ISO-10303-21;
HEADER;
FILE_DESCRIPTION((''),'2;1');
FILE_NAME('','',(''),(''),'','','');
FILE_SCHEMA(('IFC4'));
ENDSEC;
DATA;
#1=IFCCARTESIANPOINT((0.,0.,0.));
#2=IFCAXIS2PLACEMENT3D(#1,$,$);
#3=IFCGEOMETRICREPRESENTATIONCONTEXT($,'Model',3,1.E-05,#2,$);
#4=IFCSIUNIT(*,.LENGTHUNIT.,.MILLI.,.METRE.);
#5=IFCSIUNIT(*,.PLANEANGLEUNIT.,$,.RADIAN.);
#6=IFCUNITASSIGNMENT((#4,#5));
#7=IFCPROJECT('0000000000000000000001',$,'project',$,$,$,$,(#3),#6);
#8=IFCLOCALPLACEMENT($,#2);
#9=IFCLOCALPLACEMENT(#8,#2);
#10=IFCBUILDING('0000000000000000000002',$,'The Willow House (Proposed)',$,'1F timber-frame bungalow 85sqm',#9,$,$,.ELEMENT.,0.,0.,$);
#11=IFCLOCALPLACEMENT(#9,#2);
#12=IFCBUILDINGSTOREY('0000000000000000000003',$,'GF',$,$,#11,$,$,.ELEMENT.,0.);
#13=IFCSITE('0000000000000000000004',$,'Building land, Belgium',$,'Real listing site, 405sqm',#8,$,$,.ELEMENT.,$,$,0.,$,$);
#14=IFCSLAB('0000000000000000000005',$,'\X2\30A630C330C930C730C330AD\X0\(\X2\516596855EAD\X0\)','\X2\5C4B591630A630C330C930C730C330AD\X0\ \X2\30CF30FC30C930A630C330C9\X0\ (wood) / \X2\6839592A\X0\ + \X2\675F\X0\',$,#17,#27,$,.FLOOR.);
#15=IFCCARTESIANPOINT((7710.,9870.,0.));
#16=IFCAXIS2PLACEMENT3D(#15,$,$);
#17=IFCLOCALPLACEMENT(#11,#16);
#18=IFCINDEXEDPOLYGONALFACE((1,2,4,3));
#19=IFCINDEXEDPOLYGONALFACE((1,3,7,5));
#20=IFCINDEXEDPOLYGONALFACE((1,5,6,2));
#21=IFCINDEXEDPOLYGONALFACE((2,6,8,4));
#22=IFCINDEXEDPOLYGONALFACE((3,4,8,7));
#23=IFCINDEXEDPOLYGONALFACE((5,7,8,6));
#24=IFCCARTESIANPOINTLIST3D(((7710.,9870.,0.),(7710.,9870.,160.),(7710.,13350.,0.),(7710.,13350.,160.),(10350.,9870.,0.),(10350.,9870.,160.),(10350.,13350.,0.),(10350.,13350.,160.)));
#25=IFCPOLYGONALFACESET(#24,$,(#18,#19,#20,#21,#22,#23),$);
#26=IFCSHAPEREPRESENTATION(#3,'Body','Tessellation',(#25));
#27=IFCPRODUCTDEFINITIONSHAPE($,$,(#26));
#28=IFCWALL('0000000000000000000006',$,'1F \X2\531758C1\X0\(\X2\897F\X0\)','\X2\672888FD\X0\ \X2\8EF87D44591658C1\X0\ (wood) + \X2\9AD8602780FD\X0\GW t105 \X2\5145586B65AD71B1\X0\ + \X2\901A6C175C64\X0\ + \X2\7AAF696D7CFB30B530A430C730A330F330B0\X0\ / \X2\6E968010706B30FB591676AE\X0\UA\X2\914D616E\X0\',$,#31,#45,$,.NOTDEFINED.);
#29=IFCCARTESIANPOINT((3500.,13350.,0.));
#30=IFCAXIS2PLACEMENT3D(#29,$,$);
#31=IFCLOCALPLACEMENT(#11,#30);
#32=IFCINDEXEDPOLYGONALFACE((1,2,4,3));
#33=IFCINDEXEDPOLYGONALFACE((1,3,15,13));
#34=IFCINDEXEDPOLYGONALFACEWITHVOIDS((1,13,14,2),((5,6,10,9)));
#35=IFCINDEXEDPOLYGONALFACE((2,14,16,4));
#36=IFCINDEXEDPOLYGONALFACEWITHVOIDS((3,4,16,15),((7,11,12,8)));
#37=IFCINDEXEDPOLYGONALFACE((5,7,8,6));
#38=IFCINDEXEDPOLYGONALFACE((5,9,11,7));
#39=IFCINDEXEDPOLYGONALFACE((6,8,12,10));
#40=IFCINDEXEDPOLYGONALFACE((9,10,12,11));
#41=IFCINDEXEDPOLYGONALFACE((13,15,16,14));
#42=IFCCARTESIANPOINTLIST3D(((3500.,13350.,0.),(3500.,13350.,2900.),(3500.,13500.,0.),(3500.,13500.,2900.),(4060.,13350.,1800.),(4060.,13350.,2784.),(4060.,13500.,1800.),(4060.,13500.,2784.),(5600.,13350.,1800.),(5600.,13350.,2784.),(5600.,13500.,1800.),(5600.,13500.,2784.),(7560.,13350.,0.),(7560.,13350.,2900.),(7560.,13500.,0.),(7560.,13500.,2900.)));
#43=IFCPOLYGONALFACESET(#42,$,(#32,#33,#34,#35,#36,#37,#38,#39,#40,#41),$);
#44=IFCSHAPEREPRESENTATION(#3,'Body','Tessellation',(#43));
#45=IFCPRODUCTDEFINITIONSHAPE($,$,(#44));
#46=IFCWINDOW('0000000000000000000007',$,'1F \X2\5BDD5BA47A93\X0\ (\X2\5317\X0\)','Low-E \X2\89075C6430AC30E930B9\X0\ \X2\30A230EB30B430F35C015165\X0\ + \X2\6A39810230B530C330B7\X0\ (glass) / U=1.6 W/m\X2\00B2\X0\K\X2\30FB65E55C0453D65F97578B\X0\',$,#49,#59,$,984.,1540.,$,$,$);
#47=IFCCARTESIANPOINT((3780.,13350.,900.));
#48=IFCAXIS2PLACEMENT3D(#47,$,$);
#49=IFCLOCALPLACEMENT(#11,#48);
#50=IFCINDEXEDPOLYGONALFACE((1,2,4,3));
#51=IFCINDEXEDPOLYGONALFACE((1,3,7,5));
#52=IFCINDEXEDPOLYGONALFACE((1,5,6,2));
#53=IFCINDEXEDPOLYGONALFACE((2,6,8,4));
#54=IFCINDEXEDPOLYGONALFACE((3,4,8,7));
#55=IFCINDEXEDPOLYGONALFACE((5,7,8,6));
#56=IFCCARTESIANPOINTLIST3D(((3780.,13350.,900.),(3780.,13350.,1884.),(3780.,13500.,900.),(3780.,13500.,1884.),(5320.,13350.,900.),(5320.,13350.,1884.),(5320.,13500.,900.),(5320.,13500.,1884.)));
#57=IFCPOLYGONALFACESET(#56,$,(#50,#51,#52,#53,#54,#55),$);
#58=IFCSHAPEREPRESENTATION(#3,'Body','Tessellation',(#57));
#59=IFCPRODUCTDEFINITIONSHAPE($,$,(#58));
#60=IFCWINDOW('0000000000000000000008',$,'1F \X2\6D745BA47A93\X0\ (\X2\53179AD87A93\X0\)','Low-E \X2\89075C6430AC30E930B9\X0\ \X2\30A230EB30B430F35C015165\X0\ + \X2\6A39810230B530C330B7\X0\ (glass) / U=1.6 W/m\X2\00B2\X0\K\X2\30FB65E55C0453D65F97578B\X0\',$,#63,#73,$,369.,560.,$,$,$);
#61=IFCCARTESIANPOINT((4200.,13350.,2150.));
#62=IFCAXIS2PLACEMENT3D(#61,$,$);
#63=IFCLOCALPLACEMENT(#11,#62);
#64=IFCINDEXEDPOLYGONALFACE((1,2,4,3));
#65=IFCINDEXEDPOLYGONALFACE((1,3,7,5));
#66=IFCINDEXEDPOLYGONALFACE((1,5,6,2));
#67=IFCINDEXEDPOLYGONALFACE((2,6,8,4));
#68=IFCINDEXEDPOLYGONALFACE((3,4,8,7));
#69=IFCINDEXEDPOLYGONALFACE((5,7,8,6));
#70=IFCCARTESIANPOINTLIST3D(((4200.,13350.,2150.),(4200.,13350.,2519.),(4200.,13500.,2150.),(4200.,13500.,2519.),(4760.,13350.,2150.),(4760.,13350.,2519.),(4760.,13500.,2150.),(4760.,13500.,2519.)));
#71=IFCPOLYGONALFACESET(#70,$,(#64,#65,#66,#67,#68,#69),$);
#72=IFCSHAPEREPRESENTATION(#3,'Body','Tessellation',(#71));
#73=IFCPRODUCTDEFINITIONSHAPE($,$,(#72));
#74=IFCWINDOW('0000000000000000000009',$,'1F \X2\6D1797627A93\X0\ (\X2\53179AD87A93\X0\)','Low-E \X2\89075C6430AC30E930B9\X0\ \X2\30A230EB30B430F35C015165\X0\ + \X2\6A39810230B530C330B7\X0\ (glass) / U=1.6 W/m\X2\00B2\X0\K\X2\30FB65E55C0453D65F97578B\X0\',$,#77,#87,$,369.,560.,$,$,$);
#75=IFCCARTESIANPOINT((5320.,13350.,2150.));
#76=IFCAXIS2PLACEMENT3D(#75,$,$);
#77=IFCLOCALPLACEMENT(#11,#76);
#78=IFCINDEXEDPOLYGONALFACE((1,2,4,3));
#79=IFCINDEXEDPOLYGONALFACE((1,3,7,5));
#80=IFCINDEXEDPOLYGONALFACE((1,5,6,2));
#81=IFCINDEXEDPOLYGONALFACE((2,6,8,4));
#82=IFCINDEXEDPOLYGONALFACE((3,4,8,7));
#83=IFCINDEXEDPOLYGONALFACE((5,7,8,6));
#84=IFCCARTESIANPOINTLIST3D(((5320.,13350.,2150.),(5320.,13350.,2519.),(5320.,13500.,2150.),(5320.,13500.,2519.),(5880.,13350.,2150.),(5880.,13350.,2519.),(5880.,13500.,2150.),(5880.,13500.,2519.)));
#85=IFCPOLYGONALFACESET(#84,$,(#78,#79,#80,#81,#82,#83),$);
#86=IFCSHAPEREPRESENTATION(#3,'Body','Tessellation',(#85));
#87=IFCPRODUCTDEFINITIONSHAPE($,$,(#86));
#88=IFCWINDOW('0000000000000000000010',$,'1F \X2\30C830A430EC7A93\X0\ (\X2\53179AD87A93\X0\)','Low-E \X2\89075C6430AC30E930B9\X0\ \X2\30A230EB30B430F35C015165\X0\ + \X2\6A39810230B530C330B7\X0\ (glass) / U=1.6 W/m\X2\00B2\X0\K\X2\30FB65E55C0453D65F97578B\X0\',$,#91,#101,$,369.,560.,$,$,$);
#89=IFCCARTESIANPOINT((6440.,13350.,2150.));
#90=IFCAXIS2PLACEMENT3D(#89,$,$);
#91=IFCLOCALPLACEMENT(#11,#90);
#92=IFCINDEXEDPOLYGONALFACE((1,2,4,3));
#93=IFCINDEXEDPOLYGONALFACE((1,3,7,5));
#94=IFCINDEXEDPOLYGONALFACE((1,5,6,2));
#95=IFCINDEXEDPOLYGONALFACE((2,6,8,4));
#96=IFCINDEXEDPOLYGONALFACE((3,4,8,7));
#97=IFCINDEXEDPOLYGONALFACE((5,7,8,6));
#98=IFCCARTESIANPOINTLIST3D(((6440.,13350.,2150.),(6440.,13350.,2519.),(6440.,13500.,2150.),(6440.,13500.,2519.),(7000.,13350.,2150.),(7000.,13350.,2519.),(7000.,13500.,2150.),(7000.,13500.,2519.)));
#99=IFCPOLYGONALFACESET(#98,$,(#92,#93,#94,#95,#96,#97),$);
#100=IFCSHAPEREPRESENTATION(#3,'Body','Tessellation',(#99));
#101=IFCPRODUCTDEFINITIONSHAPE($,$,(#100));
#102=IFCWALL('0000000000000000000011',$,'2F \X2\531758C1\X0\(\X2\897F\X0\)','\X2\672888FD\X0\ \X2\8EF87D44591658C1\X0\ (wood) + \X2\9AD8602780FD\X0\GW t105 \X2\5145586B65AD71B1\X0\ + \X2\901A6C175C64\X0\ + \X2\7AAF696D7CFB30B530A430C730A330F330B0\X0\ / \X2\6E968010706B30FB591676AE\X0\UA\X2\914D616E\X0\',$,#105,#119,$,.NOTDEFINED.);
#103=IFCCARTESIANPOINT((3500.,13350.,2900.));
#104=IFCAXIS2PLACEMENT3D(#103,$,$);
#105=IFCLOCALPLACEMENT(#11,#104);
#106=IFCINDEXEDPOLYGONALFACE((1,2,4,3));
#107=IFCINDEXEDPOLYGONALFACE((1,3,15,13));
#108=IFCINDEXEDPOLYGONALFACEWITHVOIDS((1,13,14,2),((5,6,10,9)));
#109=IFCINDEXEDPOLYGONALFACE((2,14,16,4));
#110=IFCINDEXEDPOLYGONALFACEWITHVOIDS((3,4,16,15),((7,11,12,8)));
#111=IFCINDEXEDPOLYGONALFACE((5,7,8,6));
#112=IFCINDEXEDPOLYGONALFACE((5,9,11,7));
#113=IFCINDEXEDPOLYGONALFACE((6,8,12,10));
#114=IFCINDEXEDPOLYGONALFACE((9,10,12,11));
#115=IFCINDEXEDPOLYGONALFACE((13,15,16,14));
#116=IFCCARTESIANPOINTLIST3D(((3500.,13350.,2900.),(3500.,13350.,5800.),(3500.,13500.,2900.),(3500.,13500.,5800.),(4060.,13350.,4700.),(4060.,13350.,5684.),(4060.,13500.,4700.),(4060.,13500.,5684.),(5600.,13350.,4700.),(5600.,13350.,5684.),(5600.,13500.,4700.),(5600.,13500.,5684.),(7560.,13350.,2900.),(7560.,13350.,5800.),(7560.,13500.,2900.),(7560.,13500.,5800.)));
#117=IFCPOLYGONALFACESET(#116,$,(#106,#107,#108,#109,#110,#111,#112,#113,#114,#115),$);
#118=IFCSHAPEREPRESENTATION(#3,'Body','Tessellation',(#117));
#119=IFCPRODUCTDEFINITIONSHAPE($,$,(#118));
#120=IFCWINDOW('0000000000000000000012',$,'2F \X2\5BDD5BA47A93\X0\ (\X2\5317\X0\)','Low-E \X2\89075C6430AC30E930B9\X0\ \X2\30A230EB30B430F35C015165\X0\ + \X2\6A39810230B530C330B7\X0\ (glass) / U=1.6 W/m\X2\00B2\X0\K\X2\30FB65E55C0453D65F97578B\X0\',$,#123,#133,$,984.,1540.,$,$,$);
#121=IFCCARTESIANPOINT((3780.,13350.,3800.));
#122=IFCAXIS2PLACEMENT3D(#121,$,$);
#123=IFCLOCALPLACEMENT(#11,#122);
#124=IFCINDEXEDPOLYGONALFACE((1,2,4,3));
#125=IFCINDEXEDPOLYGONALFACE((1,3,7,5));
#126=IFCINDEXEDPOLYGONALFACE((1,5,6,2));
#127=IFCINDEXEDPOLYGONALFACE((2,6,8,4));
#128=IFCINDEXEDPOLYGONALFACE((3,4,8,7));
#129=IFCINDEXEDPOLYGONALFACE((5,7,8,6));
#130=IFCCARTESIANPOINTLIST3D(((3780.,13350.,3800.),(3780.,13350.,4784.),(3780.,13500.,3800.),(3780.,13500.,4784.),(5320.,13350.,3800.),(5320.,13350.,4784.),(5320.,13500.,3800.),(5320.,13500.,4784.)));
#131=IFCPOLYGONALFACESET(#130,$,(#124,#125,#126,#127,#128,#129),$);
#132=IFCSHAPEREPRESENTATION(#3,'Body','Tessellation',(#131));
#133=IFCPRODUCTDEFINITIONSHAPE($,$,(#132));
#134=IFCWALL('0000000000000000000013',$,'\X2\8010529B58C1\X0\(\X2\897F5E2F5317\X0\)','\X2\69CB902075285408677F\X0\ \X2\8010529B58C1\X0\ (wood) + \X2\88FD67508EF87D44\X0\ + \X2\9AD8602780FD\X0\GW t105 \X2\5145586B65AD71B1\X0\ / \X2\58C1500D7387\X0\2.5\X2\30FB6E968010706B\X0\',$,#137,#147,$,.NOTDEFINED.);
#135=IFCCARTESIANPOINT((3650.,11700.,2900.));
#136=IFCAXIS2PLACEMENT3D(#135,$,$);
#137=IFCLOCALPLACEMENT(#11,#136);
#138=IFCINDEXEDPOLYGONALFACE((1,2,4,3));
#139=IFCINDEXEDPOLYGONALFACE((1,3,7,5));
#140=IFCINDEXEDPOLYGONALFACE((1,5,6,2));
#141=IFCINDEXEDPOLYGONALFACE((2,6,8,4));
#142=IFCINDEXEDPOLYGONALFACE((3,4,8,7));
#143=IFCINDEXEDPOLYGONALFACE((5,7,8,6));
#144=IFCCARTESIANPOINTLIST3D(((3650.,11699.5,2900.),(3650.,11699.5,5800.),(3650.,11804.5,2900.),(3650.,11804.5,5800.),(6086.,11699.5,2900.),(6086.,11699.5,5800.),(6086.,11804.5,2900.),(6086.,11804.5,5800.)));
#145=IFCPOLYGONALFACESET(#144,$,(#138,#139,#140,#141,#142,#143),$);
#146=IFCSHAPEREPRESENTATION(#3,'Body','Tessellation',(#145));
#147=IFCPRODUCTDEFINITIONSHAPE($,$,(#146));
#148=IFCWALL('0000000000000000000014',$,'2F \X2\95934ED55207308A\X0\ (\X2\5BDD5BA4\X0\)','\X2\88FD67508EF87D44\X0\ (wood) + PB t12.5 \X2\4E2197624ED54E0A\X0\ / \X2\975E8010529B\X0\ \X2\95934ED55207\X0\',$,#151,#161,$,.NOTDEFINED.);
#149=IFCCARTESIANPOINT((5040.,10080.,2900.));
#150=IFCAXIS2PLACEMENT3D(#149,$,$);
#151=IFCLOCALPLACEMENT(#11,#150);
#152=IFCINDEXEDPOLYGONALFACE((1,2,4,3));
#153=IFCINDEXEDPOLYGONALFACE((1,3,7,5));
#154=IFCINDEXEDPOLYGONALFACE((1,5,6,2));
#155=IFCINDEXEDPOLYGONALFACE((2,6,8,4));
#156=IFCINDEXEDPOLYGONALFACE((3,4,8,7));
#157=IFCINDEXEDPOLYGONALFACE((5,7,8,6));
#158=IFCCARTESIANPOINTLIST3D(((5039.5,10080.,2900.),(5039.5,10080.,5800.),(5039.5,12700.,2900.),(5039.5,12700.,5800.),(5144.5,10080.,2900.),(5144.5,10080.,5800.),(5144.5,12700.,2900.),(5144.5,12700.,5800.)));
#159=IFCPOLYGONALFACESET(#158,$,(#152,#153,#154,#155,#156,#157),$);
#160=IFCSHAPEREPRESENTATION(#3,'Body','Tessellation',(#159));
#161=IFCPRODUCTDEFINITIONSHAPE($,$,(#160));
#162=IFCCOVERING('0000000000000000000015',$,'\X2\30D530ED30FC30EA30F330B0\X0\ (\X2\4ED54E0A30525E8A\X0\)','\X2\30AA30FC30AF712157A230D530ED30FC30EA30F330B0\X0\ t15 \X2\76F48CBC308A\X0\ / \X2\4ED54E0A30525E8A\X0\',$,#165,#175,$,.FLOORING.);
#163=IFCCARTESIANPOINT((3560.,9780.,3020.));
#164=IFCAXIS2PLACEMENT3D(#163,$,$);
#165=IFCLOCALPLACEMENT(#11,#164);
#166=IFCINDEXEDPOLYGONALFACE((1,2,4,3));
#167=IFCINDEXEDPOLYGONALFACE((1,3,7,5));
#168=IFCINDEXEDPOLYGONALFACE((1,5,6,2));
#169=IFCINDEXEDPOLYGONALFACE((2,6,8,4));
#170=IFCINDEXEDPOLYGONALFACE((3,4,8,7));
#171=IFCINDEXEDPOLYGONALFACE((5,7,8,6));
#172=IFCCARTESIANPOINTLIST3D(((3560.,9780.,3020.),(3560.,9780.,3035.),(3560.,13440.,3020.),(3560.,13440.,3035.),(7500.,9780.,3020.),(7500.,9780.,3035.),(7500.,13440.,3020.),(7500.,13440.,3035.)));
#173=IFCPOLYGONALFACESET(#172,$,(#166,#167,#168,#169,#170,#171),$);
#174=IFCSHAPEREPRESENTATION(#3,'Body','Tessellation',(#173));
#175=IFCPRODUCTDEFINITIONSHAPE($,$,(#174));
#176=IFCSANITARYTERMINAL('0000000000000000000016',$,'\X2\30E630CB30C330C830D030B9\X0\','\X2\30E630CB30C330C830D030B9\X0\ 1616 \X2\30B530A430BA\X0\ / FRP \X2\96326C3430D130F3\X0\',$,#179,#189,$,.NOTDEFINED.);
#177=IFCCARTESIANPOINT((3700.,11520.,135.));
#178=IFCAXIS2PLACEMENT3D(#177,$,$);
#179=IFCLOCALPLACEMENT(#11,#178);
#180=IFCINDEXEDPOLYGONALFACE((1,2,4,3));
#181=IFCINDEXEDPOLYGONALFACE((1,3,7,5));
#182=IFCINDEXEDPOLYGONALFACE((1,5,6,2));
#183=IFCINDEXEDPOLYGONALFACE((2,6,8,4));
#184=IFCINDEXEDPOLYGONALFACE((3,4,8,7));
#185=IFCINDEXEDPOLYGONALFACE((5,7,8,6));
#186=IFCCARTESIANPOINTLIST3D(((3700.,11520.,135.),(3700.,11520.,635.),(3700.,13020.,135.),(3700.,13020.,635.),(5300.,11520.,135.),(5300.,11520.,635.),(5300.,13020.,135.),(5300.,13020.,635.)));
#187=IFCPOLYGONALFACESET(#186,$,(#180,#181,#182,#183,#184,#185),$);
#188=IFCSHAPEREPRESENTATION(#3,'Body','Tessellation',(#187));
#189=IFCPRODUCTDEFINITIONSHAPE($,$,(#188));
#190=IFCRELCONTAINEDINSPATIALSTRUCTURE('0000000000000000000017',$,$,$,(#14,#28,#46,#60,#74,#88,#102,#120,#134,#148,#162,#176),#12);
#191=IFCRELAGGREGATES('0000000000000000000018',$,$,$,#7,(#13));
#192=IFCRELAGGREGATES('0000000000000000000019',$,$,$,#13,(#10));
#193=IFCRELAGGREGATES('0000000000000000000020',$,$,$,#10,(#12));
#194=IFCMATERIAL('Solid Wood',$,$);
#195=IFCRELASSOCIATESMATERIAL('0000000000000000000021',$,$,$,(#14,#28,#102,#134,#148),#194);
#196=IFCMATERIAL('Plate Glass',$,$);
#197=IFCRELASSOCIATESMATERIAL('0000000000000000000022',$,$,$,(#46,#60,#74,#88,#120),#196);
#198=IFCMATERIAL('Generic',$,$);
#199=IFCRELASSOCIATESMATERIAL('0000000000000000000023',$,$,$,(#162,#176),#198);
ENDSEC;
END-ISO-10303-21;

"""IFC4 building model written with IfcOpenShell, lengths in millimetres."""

from ifc_helpers import new_model, si_unit, frame, frame_2d, origin, place, context, project, spatial, rectangle, extrude, material, element, fill, save


model = new_model("IFC4")

# Units and contexts
model_context = context("Model", 3, precision=1e-05, world=origin())
ifc_project = project(units=[si_unit("LENGTHUNIT", "METRE", prefix="MILLI"), si_unit("PLANEANGLEUNIT", "RADIAN")], contexts=[model_context])

# Site, building, storey
site_placement = place(None, origin())
site = spatial("IfcSite", under=ifc_project, at=site_placement, Name="Building land, Belgium", ObjectType="Real listing site, 405sqm", CompositionType="ELEMENT", RefElevation=0.0)
building_placement = place(site_placement, origin())
building = spatial("IfcBuilding", under=site, at=building_placement, Name="The Willow House (Proposed)", ObjectType="1F timber-frame bungalow 85sqm", CompositionType="ELEMENT", ElevationOfRefHeight=0.0, ElevationOfTerrain=0.0)
storey_placement = place(building_placement, origin())
storey = spatial("IfcBuildingStorey", under=building, at=storey_placement, Name="GF", CompositionType="ELEMENT", Elevation=0.0)

# Slab
ifc_material_1 = material(Name="Solid Wood")
slab_placement = place(storey_placement, frame((7710.0, 9870.0, 0.0)))
element("IfcSlab", 1, at=slab_placement, inside=storey, material=ifc_material_1, Name="ウッドデッキ(入隅庭)", Description="屋外ウッドデッキ ハードウッド (wood) / 根太 + 束", PredefinedType="FLOOR", context=model_context, shape_type="SweptSolid", body=[
    extrude(rectangle(XDim=2640.0, YDim=3480.0, at=frame_2d((1320.0, 1740.0))), frame((7710.0, 9870.0, 0.0)), (0.0, 0.0, 1.0), 160.0),
])

# Wall, openings, windows
wall_1_placement = place(storey_placement, frame((3500.0, 13350.0, 0.0)))
wall_1 = element("IfcWall", 2, at=wall_1_placement, inside=storey, material=ifc_material_1, Name="1F 北壁(西)", Description="木製 軸組外壁 (wood) + 高性能GW t105 充填断熱 + 通気層 + 窯業系サイディング / 準耐火・外皮UA配慮", PredefinedType="NOTDEFINED", context=model_context, shape_type="SweptSolid", body=[
    extrude(rectangle(XDim=4060.0, YDim=150.0, at=frame_2d((2030.0, 75.0))), frame((3500.0, 13350.0, 0.0)), (0.0, 0.0, 1.0), 2900.0),
])
opening_1_placement = place(storey_placement, frame((3780.0, 13350.0, 900.0)))
opening_1 = element("IfcOpeningElement", 3, at=opening_1_placement, cuts=wall_1, PredefinedType="NOTDEFINED", context=model_context, shape_type="SweptSolid", body=[
    extrude(rectangle(XDim=1540.0, YDim=150.0, at=frame_2d((770.0, 75.0))), frame((3780.0, 13350.0, 900.0)), (0.0, 0.0, 1.0), 984.0),
])
opening_2_placement = place(storey_placement, frame((4200.0, 13350.0, 2150.0)))
opening_2 = element("IfcOpeningElement", 4, at=opening_2_placement, cuts=wall_1, PredefinedType="NOTDEFINED", context=model_context, shape_type="SweptSolid", body=[
    extrude(rectangle(XDim=560.0, YDim=150.0, at=frame_2d((280.0, 75.0))), frame((4200.0, 13350.0, 2150.0)), (0.0, 0.0, 1.0), 369.0),
])
opening_3_placement = place(storey_placement, frame((5320.0, 13350.0, 2150.0)))
opening_3 = element("IfcOpeningElement", 5, at=opening_3_placement, cuts=wall_1, PredefinedType="NOTDEFINED", context=model_context, shape_type="SweptSolid", body=[
    extrude(rectangle(XDim=560.0, YDim=150.0, at=frame_2d((280.0, 75.0))), frame((5320.0, 13350.0, 2150.0)), (0.0, 0.0, 1.0), 369.0),
])
opening_4_placement = place(storey_placement, frame((6440.0, 13350.0, 2150.0)))
opening_4 = element("IfcOpeningElement", 6, at=opening_4_placement, cuts=wall_1, PredefinedType="NOTDEFINED", context=model_context, shape_type="SweptSolid", body=[
    extrude(rectangle(XDim=560.0, YDim=150.0, at=frame_2d((280.0, 75.0))), frame((6440.0, 13350.0, 2150.0)), (0.0, 0.0, 1.0), 369.0),
])
ifc_material_2 = material(Name="Plate Glass")
window_1_placement = place(storey_placement, frame((3780.0, 13350.0, 900.0)))
window_1 = element("IfcWindow", 7, at=window_1_placement, inside=storey, material=ifc_material_2, Name="1F 寝室窓 (北)", Description="Low-E 複層ガラス アルゴン封入 + 樹脂サッシ (glass) / U=1.6 W/m²K・日射取得型", OverallHeight=984.0, OverallWidth=1540.0, context=model_context, shape_type="SweptSolid", body=[
    extrude(rectangle(XDim=1540.0, YDim=150.0, at=frame_2d((770.0, 75.0))), frame((3780.0, 13350.0, 900.0)), (0.0, 0.0, 1.0), 984.0),
])
fill(opening_1, window_1)
window_2_placement = place(storey_placement, frame((4200.0, 13350.0, 2150.0)))
window_2 = element("IfcWindow", 8, at=window_2_placement, inside=storey, material=ifc_material_2, Name="1F 浴室窓 (北高窓)", Description="Low-E 複層ガラス アルゴン封入 + 樹脂サッシ (glass) / U=1.6 W/m²K・日射取得型", OverallHeight=369.0, OverallWidth=560.0, context=model_context, shape_type="SweptSolid", body=[
    extrude(rectangle(XDim=560.0, YDim=150.0, at=frame_2d((280.0, 75.0))), frame((4200.0, 13350.0, 2150.0)), (0.0, 0.0, 1.0), 369.0),
])
fill(opening_2, window_2)
window_3_placement = place(storey_placement, frame((5320.0, 13350.0, 2150.0)))
window_3 = element("IfcWindow", 9, at=window_3_placement, inside=storey, material=ifc_material_2, Name="1F 洗面窓 (北高窓)", Description="Low-E 複層ガラス アルゴン封入 + 樹脂サッシ (glass) / U=1.6 W/m²K・日射取得型", OverallHeight=369.0, OverallWidth=560.0, context=model_context, shape_type="SweptSolid", body=[
    extrude(rectangle(XDim=560.0, YDim=150.0, at=frame_2d((280.0, 75.0))), frame((5320.0, 13350.0, 2150.0)), (0.0, 0.0, 1.0), 369.0),
])
fill(opening_3, window_3)
window_4_placement = place(storey_placement, frame((6440.0, 13350.0, 2150.0)))
window_4 = element("IfcWindow", 10, at=window_4_placement, inside=storey, material=ifc_material_2, Name="1F トイレ窓 (北高窓)", Description="Low-E 複層ガラス アルゴン封入 + 樹脂サッシ (glass) / U=1.6 W/m²K・日射取得型", OverallHeight=369.0, OverallWidth=560.0, context=model_context, shape_type="SweptSolid", body=[
    extrude(rectangle(XDim=560.0, YDim=150.0, at=frame_2d((280.0, 75.0))), frame((6440.0, 13350.0, 2150.0)), (0.0, 0.0, 1.0), 369.0),
])
fill(opening_4, window_4)

# Wall, opening, window
wall_2_placement = place(storey_placement, frame((3500.0, 13350.0, 2900.0)))
wall_2 = element("IfcWall", 11, at=wall_2_placement, inside=storey, material=ifc_material_1, Name="2F 北壁(西)", Description="木製 軸組外壁 (wood) + 高性能GW t105 充填断熱 + 通気層 + 窯業系サイディング / 準耐火・外皮UA配慮", PredefinedType="NOTDEFINED", context=model_context, shape_type="SweptSolid", body=[
    extrude(rectangle(XDim=4060.0, YDim=150.0, at=frame_2d((2030.0, 75.0))), frame((3500.0, 13350.0, 2900.0)), (0.0, 0.0, 1.0), 2900.0),
])
opening_5_placement = place(storey_placement, frame((3780.0, 13350.0, 3800.0)))
opening_5 = element("IfcOpeningElement", 12, at=opening_5_placement, cuts=wall_2, PredefinedType="NOTDEFINED", context=model_context, shape_type="SweptSolid", body=[
    extrude(rectangle(XDim=1540.0, YDim=150.0, at=frame_2d((770.0, 75.0))), frame((3780.0, 13350.0, 3800.0)), (0.0, 0.0, 1.0), 984.0),
])
window_5_placement = place(storey_placement, frame((3780.0, 13350.0, 3800.0)))
window_5 = element("IfcWindow", 13, at=window_5_placement, inside=storey, material=ifc_material_2, Name="2F 寝室窓 (北)", Description="Low-E 複層ガラス アルゴン封入 + 樹脂サッシ (glass) / U=1.6 W/m²K・日射取得型", OverallHeight=984.0, OverallWidth=1540.0, context=model_context, shape_type="SweptSolid", body=[
    extrude(rectangle(XDim=1540.0, YDim=150.0, at=frame_2d((770.0, 75.0))), frame((3780.0, 13350.0, 3800.0)), (0.0, 0.0, 1.0), 984.0),
])
fill(opening_5, window_5)

# Walls
wall_3_placement = place(storey_placement, frame((3650.0, 11700.0, 2900.0)))
element("IfcWall", 14, at=wall_3_placement, inside=storey, material=ifc_material_1, Name="耐力壁(西帯北)", Description="構造用合板 耐力壁 (wood) + 製材軸組 + 高性能GW t105 充填断熱 / 壁倍率2.5・準耐火", PredefinedType="NOTDEFINED", context=model_context, shape_type="SweptSolid", body=[
    extrude(rectangle(XDim=2436.0, YDim=105.0, at=frame_2d((1218.0, 52.0))), frame((3650.0, 11700.0, 2900.0)), (0.0, 0.0, 1.0), 2900.0),
])
wall_4_placement = place(storey_placement, frame((5040.0, 10080.0, 2900.0)))
element("IfcWall", 15, at=wall_4_placement, inside=storey, material=ifc_material_1, Name="2F 間仕切り (寝室)", Description="製材軸組 (wood) + PB t12.5 両面仕上 / 非耐力 間仕切", PredefinedType="NOTDEFINED", context=model_context, shape_type="SweptSolid", body=[
    extrude(rectangle(XDim=105.0, YDim=2620.0, at=frame_2d((52.0, 1310.0))), frame((5040.0, 10080.0, 2900.0)), (0.0, 0.0, 1.0), 2900.0),
])

# Covering
ifc_material_3 = material(Name="Generic")
covering_placement = place(storey_placement, frame((3560.0, 9780.0, 3020.0)))
element("IfcCovering", 16, at=covering_placement, inside=storey, material=ifc_material_3, Name="フローリング (仕上げ床)", Description="オーク無垢フローリング t15 直貼り / 仕上げ床", PredefinedType="FLOORING", context=model_context, shape_type="SweptSolid", body=[
    extrude(rectangle(XDim=3940.0, YDim=3660.0, at=frame_2d((1970.0, 1830.0))), frame((3560.0, 9780.0, 3020.0)), (0.0, 0.0, 1.0), 15.0),
])

# Sanitary terminal
sanitary_terminal_1_placement = place(storey_placement, frame((3700.0, 11520.0, 135.0)))
element("IfcSanitaryTerminal", 17, at=sanitary_terminal_1_placement, inside=storey, material=ifc_material_3, Name="ユニットバス", Description="ユニットバス 1616 サイズ / FRP 防水パン", PredefinedType="NOTDEFINED", context=model_context, shape_type="SweptSolid", body=[
    extrude(rectangle(XDim=1600.0, YDim=1500.0, at=frame_2d((800.0, 750.0))), frame((3700.0, 11520.0, 135.0)), (0.0, 0.0, 1.0), 500.0),
])

save(model, "model.ifc")
